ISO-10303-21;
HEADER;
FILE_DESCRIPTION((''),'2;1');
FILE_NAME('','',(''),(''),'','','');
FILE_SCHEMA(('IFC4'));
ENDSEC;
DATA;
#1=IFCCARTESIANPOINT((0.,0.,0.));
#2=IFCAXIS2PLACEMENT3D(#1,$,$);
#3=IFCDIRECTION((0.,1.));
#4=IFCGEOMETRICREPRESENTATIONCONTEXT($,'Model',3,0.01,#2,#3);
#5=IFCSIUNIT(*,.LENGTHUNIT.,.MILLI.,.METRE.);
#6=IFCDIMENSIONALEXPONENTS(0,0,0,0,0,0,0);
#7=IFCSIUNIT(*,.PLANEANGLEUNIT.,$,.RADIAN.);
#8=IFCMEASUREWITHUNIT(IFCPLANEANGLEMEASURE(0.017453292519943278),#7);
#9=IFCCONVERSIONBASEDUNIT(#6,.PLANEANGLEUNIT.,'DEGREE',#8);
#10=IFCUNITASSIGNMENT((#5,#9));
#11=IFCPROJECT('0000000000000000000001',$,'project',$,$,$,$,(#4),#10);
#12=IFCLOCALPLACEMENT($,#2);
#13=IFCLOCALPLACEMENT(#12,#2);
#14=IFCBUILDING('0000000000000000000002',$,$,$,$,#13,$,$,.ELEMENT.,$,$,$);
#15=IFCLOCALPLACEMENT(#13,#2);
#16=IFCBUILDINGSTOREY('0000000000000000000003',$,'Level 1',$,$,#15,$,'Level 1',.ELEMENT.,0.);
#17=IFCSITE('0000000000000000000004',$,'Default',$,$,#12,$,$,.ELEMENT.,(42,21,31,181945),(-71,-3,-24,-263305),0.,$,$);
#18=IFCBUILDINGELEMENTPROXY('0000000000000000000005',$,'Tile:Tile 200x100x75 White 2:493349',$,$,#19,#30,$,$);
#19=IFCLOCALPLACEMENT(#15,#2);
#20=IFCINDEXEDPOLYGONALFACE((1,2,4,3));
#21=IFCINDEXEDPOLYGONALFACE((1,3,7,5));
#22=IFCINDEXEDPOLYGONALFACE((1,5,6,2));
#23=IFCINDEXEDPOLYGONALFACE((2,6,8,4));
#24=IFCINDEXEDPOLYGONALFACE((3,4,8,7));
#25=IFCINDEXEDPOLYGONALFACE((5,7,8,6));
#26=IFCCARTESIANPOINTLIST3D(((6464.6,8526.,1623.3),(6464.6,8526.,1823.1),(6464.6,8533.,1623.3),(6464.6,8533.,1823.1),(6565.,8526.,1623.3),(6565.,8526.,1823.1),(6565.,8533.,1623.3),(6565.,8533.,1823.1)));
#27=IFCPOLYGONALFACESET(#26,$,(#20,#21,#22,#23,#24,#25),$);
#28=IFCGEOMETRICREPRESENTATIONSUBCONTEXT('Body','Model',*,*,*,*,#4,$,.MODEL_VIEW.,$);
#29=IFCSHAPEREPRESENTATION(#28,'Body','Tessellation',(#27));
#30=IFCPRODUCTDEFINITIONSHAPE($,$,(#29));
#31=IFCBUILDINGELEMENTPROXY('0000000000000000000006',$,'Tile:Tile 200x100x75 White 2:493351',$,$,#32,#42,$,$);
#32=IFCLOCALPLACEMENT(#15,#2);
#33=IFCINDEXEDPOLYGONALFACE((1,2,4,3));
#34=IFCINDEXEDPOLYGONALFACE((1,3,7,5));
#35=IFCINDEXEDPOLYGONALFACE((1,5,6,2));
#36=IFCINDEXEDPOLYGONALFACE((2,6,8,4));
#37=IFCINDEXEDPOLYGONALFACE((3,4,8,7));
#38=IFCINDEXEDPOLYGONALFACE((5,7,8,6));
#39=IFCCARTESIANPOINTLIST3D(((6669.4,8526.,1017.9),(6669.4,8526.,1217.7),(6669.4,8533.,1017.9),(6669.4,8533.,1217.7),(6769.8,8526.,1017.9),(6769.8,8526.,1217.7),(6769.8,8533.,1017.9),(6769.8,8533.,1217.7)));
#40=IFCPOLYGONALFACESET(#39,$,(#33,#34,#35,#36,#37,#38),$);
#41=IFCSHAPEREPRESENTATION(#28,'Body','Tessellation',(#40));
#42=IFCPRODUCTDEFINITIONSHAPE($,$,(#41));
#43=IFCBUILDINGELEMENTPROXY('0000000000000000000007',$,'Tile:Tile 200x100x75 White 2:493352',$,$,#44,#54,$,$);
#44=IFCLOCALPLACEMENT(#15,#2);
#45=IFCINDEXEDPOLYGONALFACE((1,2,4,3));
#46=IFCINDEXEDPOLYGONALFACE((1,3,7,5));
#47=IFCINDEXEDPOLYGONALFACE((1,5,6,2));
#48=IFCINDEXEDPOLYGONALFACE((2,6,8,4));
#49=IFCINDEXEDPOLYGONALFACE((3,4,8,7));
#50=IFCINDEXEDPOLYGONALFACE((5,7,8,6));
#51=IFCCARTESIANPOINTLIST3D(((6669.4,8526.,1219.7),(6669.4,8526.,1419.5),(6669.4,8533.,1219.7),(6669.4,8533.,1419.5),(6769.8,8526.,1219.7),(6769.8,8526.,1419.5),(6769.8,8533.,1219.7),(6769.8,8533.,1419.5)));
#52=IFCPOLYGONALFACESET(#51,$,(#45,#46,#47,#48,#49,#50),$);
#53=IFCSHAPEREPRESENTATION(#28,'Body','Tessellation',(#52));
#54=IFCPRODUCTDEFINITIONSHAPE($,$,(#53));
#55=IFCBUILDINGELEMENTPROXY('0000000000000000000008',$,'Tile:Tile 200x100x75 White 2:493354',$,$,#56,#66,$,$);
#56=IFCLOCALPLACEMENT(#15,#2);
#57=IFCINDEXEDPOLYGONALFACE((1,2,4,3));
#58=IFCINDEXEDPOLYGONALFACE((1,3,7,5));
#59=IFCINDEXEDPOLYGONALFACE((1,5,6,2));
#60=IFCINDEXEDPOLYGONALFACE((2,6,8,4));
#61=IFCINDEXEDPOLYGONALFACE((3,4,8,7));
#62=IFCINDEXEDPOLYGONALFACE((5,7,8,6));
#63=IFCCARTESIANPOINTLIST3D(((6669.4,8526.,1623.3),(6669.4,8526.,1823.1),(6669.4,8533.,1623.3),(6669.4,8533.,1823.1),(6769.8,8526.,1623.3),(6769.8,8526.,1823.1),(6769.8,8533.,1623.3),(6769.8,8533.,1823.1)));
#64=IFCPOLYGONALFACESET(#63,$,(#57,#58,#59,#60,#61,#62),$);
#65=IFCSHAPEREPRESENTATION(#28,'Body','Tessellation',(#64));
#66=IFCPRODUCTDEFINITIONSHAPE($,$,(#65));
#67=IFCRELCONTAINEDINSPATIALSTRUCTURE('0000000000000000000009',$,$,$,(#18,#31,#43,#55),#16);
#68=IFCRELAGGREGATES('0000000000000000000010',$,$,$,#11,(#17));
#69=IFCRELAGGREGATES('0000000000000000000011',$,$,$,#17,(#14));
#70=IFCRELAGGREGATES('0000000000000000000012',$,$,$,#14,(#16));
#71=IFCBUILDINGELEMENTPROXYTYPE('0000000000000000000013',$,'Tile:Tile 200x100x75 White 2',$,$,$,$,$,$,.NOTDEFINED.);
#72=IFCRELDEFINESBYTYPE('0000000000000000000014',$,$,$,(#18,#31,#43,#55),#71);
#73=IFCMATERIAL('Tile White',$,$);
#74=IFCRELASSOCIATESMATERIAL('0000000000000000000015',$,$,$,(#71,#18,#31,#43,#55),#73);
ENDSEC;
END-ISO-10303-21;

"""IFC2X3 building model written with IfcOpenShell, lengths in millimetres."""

from ifc_helpers import new_model, entity, si_unit, converted_unit, direction, frame, frame_2d, origin, place, context, subcontext, project, spatial, rectangle, extrude, source, transform, mapped, material, type_object, type_shapes, element, save


model = new_model("IFC2X3")

# Units and contexts
model_context = context("Model", 3, precision=0.01, world=origin(), true_north=direction((0.0, 1.0)))
body_context = subcontext(model_context, "Body", "Model", "MODEL_VIEW")
ifc_project = project(units=[si_unit("LENGTHUNIT", "METRE", prefix="MILLI"), converted_unit("PLANEANGLEUNIT", "DEGREE", entity("IfcPlaneAngleMeasure", 0.017453292519943278), si_unit("PLANEANGLEUNIT", "RADIAN"), dimensions=[0, 0, 0, 0, 0, 0, 0])], contexts=[model_context])

# Site, building, storey
site_placement = place(None, origin())
site = spatial("IfcSite", under=ifc_project, at=site_placement, Name="Default", CompositionType="ELEMENT", RefLatitude=(42, 21, 31, 181945), RefLongitude=(-71, -3, -24, -263305), RefElevation=0.0)
building_placement = place(site_placement, origin())
building = spatial("IfcBuilding", under=site, at=building_placement, CompositionType="ELEMENT")
storey_placement = place(building_placement, origin())
storey = spatial("IfcBuildingStorey", under=building, at=storey_placement, Name="Level 1", LongName="Level 1", CompositionType="ELEMENT", Elevation=0.0)

# Building element proxies
ifc_material = material(Name="Tile White")
building_element_proxy_type_1 = type_object("IfcBuildingElementProxyType", Name="Tile:Tile 200x100x75 White 2", PredefinedType="NOTDEFINED", material=ifc_material)
shared_shape_1 = source(origin(), body_context, "Body", "SweptSolid", [
    extrude(rectangle(XDim=199.8, YDim=100.4, at=frame_2d((0.0, 0.0), x_axis=(1.0, 0.0))), frame((-50.2, -99.9, 0.0), z_axis=(0.0, 0.0, 1.0), x_axis=(0.0, -1.0, 0.0)), (0.0, 0.0, 1.0), 7.0),
])
type_shapes(building_element_proxy_type_1, [shared_shape_1])
for number, where, z_axis, x_axis, name in (
    (1, (6565.0, 8533.0, 1823.1), (0.0, -1.0, 0.0), (1.0, 0.0, 0.0), "Tile:Tile 200x100x75 White 2:493349"),
    (2, (6769.8, 8533.0, 1217.7), (0.0, -1.0, 0.0), (1.0, 0.0, 0.0), "Tile:Tile 200x100x75 White 2:493351"),
    (3, (6769.8, 8533.0, 1419.5), (0.0, -1.0, 0.0), (1.0, 0.0, 0.0), "Tile:Tile 200x100x75 White 2:493352"),
    (4, (6769.8, 8533.0, 1823.1), (0.0, -1.0, 0.0), (1.0, 0.0, 0.0), "Tile:Tile 200x100x75 White 2:493354"),
):
    element("IfcBuildingElementProxy", number, at=place(storey_placement, frame(where, z_axis=z_axis, x_axis=x_axis)), inside=storey, type_object=building_element_proxy_type_1, material=ifc_material, Name=name, context=body_context, shape_type="MappedRepresentation", body=[
        mapped(shared_shape_1, transform((0.0, 0.0, 0.0), scale=1.0)),
    ])

save(model, "model.ifc")
